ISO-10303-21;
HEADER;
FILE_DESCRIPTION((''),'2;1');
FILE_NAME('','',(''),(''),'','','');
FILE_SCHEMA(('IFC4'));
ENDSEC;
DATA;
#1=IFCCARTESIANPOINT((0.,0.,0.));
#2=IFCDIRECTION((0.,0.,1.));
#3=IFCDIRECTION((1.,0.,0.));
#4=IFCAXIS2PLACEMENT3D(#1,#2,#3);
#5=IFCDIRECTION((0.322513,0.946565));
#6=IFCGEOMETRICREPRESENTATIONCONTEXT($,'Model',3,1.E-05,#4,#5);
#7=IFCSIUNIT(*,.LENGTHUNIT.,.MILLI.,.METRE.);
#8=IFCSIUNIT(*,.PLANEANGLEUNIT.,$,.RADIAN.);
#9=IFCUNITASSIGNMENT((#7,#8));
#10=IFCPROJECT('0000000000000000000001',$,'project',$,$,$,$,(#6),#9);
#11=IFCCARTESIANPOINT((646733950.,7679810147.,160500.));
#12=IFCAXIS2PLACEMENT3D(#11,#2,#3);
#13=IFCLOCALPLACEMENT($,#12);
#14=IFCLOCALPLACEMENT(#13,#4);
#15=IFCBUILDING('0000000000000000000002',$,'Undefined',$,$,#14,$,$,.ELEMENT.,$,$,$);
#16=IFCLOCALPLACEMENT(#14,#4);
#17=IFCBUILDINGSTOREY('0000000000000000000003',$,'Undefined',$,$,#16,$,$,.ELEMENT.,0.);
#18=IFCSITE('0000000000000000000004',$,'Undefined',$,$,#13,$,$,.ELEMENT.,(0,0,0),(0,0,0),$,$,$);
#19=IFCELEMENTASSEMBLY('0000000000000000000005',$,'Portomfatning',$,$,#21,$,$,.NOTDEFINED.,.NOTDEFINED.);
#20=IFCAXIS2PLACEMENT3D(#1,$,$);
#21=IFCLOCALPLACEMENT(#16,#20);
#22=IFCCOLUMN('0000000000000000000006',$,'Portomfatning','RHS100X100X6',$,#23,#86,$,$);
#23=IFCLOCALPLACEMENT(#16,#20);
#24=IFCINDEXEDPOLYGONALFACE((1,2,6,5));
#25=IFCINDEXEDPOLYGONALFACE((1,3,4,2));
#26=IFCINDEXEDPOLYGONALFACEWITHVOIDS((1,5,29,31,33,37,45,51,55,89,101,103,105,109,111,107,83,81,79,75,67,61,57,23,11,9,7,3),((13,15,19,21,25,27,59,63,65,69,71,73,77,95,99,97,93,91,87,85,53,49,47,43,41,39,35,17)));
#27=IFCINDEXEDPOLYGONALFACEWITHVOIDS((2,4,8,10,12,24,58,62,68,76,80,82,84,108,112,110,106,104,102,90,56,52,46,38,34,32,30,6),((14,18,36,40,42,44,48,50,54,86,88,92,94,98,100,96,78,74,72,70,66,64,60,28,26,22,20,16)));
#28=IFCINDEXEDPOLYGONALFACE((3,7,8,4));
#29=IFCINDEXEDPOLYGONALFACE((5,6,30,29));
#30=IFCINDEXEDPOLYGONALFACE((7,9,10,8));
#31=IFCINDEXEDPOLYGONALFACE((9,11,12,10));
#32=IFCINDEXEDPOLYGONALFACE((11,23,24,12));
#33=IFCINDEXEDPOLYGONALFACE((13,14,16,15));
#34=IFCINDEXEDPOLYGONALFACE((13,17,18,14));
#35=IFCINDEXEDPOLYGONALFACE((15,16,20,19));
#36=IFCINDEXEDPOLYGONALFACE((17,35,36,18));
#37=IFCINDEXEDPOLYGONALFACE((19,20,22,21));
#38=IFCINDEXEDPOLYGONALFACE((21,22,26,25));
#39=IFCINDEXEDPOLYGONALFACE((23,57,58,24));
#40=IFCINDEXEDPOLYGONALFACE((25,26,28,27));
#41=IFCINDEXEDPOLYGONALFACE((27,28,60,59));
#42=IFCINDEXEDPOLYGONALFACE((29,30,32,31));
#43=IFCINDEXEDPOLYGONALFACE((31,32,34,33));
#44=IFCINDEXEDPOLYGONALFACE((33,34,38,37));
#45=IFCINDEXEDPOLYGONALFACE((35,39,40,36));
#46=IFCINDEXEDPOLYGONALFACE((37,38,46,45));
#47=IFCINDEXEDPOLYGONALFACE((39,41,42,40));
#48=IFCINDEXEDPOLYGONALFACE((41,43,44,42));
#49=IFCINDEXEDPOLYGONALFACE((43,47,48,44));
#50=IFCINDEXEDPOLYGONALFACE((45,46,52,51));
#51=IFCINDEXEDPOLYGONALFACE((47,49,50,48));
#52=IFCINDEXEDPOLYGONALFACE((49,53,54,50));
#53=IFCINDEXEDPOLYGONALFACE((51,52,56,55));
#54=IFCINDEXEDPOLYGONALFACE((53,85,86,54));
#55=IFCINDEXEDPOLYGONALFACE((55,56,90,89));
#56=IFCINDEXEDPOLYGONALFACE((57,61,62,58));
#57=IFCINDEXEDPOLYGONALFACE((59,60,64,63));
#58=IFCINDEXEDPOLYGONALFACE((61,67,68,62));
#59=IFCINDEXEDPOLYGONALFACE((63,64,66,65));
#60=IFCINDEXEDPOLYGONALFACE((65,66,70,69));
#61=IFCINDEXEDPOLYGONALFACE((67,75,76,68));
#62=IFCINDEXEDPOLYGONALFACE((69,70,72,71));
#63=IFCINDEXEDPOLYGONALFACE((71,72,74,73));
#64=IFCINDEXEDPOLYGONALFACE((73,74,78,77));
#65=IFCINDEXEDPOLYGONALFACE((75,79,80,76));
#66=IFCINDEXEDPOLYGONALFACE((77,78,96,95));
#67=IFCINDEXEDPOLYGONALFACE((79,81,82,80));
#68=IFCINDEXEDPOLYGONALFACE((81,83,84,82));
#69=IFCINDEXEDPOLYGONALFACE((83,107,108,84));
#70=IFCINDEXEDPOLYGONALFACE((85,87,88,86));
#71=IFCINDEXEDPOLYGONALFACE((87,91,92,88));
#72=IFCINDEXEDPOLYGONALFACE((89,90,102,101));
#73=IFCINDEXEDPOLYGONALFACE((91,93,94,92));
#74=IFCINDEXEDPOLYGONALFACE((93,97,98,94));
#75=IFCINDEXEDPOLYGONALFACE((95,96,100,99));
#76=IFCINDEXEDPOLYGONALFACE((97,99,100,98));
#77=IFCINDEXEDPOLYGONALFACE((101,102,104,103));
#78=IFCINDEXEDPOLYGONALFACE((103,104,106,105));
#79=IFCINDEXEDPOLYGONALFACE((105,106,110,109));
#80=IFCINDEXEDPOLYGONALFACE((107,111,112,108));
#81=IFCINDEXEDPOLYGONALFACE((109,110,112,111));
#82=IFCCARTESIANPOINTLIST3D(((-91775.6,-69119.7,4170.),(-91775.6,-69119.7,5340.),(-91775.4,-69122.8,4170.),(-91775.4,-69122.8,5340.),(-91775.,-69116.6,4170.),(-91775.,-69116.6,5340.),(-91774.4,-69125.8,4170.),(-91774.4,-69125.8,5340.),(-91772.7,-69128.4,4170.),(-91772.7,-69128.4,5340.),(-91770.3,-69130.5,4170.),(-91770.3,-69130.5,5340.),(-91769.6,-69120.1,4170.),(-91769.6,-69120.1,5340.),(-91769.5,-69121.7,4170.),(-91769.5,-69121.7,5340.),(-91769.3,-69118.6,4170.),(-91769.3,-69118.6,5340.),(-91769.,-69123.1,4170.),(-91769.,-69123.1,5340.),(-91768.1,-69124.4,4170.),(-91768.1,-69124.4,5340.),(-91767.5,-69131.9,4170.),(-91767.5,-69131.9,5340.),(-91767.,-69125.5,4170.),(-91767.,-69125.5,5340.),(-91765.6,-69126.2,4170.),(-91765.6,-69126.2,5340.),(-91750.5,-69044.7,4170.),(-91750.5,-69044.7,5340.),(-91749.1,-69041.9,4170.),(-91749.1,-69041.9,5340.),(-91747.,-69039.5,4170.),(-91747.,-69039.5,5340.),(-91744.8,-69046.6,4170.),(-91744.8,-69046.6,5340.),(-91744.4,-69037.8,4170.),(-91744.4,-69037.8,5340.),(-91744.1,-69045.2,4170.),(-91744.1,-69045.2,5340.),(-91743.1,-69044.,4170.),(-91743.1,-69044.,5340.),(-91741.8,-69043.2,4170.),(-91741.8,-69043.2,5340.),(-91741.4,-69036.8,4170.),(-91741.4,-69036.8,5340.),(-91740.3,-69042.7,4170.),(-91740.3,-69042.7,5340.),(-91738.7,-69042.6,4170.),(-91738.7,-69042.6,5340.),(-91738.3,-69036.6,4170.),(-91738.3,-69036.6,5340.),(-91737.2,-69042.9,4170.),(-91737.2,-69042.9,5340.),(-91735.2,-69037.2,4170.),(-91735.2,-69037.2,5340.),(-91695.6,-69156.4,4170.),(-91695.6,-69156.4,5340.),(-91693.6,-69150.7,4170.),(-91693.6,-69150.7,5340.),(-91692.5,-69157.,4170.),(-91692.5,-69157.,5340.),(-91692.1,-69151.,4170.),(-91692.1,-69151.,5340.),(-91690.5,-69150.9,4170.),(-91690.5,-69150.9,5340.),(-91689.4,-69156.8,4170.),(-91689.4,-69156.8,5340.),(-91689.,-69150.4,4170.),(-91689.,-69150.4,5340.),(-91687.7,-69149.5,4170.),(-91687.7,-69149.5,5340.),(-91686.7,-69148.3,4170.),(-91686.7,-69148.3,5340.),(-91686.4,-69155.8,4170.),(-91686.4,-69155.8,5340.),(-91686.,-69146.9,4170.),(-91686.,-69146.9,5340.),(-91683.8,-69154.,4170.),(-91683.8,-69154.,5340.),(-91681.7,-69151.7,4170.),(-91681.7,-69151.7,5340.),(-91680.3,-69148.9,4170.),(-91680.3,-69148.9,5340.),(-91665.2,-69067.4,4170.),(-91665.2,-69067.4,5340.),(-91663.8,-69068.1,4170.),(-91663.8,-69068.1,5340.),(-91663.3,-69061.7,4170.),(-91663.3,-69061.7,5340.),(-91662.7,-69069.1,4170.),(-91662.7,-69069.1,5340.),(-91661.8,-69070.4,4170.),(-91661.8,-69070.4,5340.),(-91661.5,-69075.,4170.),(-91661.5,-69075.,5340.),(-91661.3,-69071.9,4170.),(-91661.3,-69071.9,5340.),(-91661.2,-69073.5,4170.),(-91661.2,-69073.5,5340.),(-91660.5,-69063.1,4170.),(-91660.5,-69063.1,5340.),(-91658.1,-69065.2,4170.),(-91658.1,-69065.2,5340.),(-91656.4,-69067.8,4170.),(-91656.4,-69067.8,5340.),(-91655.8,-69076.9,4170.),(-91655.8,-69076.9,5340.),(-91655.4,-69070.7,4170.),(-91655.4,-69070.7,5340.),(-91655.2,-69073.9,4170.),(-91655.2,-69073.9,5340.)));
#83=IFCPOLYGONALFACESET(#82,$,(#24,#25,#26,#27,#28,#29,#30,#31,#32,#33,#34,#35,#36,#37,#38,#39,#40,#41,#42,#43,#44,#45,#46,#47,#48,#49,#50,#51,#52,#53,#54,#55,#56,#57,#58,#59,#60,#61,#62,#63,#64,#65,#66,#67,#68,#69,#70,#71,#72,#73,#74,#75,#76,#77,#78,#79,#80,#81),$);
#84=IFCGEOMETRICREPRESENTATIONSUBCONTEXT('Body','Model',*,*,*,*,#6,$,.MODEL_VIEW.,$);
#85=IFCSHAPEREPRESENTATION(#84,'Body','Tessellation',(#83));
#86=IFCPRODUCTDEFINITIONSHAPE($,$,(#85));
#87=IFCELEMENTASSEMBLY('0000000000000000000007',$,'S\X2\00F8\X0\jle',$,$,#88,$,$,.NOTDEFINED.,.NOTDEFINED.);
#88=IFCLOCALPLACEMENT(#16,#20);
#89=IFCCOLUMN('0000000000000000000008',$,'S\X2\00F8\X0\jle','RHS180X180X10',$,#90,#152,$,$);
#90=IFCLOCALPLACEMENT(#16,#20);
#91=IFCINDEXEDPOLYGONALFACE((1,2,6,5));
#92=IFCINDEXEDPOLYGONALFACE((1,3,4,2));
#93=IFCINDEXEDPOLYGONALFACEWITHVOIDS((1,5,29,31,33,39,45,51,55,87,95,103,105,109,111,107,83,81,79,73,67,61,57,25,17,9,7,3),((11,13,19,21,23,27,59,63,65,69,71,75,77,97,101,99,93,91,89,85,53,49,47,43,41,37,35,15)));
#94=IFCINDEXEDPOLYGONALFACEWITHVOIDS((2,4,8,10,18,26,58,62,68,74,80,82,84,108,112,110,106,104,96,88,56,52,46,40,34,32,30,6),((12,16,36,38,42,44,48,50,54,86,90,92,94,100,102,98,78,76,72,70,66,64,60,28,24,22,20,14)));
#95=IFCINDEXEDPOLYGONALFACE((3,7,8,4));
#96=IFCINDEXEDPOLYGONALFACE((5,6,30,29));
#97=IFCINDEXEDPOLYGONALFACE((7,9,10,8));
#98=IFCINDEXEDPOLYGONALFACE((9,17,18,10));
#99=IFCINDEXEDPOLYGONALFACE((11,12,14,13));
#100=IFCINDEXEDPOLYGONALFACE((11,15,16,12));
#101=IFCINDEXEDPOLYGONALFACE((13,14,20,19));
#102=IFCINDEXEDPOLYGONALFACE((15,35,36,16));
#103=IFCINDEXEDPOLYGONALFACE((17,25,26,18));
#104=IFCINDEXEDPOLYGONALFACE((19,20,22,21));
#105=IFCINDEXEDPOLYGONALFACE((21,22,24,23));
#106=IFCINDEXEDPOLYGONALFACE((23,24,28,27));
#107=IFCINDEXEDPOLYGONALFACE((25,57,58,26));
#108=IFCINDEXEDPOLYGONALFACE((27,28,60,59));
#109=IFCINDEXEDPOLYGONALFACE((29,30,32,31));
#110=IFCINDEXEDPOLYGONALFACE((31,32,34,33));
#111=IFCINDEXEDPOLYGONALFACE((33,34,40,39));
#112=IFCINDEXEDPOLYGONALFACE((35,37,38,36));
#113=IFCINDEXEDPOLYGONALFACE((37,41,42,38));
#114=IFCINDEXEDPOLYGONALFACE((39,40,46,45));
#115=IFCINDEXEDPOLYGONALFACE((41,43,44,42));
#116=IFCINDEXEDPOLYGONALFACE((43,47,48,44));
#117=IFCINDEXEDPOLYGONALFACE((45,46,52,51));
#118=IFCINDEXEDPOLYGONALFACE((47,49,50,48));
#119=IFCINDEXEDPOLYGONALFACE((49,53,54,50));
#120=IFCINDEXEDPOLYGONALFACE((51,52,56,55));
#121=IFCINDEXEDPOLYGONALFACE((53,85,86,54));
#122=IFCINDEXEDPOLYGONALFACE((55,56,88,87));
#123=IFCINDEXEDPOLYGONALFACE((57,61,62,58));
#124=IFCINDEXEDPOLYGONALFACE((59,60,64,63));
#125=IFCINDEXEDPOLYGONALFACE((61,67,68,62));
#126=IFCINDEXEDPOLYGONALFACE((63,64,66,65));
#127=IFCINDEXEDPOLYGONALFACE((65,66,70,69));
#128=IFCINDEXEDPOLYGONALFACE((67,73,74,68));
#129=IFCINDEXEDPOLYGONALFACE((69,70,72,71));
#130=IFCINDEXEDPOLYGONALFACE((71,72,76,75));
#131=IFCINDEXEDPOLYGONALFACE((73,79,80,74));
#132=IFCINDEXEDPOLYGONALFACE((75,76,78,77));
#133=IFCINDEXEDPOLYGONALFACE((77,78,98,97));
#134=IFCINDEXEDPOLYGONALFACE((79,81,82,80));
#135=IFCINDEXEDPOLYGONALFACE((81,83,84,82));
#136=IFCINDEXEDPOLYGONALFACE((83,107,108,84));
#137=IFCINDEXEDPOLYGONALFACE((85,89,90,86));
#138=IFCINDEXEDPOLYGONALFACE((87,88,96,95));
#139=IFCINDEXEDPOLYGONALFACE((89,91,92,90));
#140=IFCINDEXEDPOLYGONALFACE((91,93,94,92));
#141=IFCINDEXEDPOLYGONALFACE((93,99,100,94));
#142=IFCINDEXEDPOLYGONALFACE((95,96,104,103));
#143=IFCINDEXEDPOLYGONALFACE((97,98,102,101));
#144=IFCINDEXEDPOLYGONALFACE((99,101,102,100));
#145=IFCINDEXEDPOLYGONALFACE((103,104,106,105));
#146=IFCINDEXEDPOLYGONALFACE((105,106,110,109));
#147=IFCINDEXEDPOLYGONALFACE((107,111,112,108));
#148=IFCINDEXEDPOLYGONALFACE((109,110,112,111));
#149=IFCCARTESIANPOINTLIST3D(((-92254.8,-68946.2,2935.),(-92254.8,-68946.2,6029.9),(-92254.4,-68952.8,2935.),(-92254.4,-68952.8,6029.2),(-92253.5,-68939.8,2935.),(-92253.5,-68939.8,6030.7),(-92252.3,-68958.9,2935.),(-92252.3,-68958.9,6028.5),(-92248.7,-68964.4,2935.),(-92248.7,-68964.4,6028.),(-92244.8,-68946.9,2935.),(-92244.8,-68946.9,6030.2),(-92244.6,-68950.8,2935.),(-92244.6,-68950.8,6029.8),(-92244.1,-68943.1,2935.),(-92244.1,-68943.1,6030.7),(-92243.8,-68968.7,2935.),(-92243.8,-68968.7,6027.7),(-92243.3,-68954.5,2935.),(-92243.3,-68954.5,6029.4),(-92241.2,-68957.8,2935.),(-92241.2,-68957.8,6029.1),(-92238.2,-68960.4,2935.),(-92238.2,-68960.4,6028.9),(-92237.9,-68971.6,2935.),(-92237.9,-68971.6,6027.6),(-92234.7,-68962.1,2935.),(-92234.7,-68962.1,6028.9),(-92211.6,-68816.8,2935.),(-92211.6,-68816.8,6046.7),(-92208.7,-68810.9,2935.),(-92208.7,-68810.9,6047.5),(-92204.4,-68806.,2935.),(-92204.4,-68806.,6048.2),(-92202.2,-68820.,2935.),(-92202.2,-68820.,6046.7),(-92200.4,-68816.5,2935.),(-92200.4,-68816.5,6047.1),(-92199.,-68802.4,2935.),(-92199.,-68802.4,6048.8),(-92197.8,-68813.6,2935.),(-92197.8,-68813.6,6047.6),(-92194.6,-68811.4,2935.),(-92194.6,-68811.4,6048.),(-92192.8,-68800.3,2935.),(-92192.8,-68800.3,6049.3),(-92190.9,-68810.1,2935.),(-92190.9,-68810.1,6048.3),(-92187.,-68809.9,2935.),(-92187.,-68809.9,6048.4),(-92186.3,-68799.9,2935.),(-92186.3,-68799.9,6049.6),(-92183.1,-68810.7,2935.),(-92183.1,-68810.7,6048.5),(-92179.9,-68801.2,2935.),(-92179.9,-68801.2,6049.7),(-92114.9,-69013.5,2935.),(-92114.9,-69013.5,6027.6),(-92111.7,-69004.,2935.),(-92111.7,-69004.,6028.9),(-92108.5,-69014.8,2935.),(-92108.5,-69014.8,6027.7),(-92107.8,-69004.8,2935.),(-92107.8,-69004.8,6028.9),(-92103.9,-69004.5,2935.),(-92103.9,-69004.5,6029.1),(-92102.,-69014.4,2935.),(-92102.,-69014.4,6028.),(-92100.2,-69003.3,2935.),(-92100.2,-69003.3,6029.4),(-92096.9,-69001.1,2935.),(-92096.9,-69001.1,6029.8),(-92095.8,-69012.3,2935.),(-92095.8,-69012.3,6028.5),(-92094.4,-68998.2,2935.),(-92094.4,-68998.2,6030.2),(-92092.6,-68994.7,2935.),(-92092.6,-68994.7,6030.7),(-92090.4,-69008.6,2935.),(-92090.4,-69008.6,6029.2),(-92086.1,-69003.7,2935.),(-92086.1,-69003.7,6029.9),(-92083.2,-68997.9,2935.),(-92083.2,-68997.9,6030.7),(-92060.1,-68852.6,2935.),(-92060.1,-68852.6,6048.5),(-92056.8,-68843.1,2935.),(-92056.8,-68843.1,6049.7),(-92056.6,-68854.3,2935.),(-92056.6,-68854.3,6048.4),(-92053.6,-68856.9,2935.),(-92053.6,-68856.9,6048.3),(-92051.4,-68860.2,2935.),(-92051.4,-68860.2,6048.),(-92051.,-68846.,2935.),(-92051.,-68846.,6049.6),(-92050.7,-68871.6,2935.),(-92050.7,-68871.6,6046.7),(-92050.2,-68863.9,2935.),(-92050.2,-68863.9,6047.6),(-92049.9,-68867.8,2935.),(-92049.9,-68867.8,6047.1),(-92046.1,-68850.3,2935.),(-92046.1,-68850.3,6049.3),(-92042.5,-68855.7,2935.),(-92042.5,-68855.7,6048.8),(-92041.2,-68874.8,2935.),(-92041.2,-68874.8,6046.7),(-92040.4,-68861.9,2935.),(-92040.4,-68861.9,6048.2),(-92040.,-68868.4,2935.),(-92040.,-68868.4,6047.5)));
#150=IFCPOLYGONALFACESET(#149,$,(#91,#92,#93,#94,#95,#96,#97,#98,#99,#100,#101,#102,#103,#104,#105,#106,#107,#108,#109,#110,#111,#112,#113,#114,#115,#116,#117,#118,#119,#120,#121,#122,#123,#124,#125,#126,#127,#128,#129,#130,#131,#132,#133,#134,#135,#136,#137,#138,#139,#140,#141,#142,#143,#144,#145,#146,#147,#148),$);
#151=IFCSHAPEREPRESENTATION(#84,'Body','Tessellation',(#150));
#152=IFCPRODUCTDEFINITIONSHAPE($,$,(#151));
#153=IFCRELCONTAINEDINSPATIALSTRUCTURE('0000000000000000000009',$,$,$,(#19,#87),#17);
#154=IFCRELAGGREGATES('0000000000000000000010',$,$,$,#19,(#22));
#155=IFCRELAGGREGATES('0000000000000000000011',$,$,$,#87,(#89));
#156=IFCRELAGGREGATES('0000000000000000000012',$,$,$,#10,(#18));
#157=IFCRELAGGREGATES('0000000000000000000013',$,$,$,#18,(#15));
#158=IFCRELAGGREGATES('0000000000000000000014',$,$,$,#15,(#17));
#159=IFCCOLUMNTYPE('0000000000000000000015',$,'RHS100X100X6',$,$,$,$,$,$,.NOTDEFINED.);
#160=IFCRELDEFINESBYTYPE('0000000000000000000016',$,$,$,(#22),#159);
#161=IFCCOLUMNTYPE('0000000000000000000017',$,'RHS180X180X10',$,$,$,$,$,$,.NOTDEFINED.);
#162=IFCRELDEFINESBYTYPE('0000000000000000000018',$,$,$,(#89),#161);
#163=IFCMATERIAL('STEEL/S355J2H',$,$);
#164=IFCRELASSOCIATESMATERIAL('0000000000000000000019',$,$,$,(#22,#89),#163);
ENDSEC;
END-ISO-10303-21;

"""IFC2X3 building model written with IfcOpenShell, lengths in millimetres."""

from ifc_helpers import new_model, si_unit, direction, frame, origin_with_axes, origin_2d_with_axis, place, context, subcontext, project, spatial, hollow_rectangle, extrude, clip, halfspace, material, type_object, element, aggregate, save


model = new_model("IFC2X3")

# Units and contexts
model_context = context("Model", 3, precision=1e-05, world=origin_with_axes(), true_north=direction((0.322513, 0.946565)))
body_context = subcontext(model_context, "Body", "Model", "MODEL_VIEW")
ifc_project = project(units=[si_unit("LENGTHUNIT", "METRE", prefix="MILLI"), si_unit("PLANEANGLEUNIT", "RADIAN")], contexts=[model_context])

# Site, building, storey
site_placement = place(None, frame((646733950.0, 7679810147.0, 160500.0), z_axis=(0.0, 0.0, 1.0), x_axis=(1.0, 0.0, 0.0)))
site = spatial("IfcSite", under=ifc_project, at=site_placement, Name="Undefined", CompositionType="ELEMENT", RefLatitude=(0, 0, 0), RefLongitude=(0, 0, 0))
building_placement = place(site_placement, origin_with_axes())
building = spatial("IfcBuilding", under=site, at=building_placement, Name="Undefined", CompositionType="ELEMENT")
storey_placement = place(building_placement, origin_with_axes())
storey = spatial("IfcBuildingStorey", under=building, at=storey_placement, Name="Undefined", CompositionType="ELEMENT", Elevation=0.0)

# Element assemblies, columns
assembly_1_placement = place(storey_placement, origin_with_axes())
assembly_1 = element("IfcElementAssembly", 1, at=assembly_1_placement, inside=storey, Name="Portomfatning", AssemblyPlace="NOTDEFINED", PredefinedType="NOTDEFINED")
ifc_material_1 = material(Name="STEEL/S355J2H")
column_type_1 = type_object("IfcColumnType", Name="RHS100X100X6", PredefinedType="NOTDEFINED")
column_1_placement = place(assembly_1_placement, frame((-91715.4, -69096.8, 4160.0), z_axis=(0.0, 0.0, 1.0), x_axis=(0.946565, -0.322513, 0.0)))
column_1 = element("IfcColumn", 2, at=column_1_placement, type_object=column_type_1, material=ifc_material_1, Name="Portomfatning", Description="RHS100X100X6", context=body_context, shape_type="Clipping", body=[
    clip(clip(extrude(hollow_rectangle(XDim=100.0, YDim=100.0, WallThickness=6.0, InnerFilletRadius=6.0, OuterFilletRadius=12.0, at=origin_2d_with_axis()), frame((0.0, 0.0, 1190.0), z_axis=(0.0, 0.0, -1.0), x_axis=(0.0, 1.0, 0.0)), (0.0, 0.0, 1.0), 1190.0), halfspace(frame((50.0, 0.0, 1180.0), z_axis=(0.0, 0.0, -1.0), x_axis=(0.0, 1.0, 0.0)), True)), halfspace(frame((50.0, 0.0, 10.0), z_axis=(0.0, 0.0, 1.0), x_axis=(0.0, -1.0, 0.0)), True)),
])
assembly_2_placement = place(storey_placement, origin_with_axes())
assembly_2 = element("IfcElementAssembly", 3, at=assembly_2_placement, inside=storey, Name="Søjle", AssemblyPlace="NOTDEFINED", PredefinedType="NOTDEFINED")
column_type_2 = type_object("IfcColumnType", Name="RHS180X180X10", PredefinedType="NOTDEFINED")
column_2_placement = place(assembly_2_placement, frame((-92147.4, -68907.3, 2935.0), z_axis=(0.0, 0.0, 1.0), x_axis=(0.322513, 0.946565, 0.0)))
column_2 = element("IfcColumn", 4, at=column_2_placement, type_object=column_type_2, material=ifc_material_1, Name="Søjle", Description="RHS180X180X10", context=body_context, shape_type="Clipping", body=[
    clip(extrude(hollow_rectangle(XDim=180.0, YDim=180.0, WallThickness=10.0, InnerFilletRadius=15.0, OuterFilletRadius=25.0, at=origin_2d_with_axis()), frame((0.0, 0.0, 3114.8), z_axis=(0.0, 0.0, -1.0), x_axis=(0.0, 1.0, 0.0)), (0.0, 0.0, 1.0), 3114.8), halfspace(frame((-90.0, 0.0, 3092.6), z_axis=(0.121869, 0.0, -0.992546), x_axis=(0.0, -1.0, 0.0)), True)),
])

aggregate(assembly_1, [column_1])
aggregate(assembly_2, [column_2])

save(model, "model.ifc")
